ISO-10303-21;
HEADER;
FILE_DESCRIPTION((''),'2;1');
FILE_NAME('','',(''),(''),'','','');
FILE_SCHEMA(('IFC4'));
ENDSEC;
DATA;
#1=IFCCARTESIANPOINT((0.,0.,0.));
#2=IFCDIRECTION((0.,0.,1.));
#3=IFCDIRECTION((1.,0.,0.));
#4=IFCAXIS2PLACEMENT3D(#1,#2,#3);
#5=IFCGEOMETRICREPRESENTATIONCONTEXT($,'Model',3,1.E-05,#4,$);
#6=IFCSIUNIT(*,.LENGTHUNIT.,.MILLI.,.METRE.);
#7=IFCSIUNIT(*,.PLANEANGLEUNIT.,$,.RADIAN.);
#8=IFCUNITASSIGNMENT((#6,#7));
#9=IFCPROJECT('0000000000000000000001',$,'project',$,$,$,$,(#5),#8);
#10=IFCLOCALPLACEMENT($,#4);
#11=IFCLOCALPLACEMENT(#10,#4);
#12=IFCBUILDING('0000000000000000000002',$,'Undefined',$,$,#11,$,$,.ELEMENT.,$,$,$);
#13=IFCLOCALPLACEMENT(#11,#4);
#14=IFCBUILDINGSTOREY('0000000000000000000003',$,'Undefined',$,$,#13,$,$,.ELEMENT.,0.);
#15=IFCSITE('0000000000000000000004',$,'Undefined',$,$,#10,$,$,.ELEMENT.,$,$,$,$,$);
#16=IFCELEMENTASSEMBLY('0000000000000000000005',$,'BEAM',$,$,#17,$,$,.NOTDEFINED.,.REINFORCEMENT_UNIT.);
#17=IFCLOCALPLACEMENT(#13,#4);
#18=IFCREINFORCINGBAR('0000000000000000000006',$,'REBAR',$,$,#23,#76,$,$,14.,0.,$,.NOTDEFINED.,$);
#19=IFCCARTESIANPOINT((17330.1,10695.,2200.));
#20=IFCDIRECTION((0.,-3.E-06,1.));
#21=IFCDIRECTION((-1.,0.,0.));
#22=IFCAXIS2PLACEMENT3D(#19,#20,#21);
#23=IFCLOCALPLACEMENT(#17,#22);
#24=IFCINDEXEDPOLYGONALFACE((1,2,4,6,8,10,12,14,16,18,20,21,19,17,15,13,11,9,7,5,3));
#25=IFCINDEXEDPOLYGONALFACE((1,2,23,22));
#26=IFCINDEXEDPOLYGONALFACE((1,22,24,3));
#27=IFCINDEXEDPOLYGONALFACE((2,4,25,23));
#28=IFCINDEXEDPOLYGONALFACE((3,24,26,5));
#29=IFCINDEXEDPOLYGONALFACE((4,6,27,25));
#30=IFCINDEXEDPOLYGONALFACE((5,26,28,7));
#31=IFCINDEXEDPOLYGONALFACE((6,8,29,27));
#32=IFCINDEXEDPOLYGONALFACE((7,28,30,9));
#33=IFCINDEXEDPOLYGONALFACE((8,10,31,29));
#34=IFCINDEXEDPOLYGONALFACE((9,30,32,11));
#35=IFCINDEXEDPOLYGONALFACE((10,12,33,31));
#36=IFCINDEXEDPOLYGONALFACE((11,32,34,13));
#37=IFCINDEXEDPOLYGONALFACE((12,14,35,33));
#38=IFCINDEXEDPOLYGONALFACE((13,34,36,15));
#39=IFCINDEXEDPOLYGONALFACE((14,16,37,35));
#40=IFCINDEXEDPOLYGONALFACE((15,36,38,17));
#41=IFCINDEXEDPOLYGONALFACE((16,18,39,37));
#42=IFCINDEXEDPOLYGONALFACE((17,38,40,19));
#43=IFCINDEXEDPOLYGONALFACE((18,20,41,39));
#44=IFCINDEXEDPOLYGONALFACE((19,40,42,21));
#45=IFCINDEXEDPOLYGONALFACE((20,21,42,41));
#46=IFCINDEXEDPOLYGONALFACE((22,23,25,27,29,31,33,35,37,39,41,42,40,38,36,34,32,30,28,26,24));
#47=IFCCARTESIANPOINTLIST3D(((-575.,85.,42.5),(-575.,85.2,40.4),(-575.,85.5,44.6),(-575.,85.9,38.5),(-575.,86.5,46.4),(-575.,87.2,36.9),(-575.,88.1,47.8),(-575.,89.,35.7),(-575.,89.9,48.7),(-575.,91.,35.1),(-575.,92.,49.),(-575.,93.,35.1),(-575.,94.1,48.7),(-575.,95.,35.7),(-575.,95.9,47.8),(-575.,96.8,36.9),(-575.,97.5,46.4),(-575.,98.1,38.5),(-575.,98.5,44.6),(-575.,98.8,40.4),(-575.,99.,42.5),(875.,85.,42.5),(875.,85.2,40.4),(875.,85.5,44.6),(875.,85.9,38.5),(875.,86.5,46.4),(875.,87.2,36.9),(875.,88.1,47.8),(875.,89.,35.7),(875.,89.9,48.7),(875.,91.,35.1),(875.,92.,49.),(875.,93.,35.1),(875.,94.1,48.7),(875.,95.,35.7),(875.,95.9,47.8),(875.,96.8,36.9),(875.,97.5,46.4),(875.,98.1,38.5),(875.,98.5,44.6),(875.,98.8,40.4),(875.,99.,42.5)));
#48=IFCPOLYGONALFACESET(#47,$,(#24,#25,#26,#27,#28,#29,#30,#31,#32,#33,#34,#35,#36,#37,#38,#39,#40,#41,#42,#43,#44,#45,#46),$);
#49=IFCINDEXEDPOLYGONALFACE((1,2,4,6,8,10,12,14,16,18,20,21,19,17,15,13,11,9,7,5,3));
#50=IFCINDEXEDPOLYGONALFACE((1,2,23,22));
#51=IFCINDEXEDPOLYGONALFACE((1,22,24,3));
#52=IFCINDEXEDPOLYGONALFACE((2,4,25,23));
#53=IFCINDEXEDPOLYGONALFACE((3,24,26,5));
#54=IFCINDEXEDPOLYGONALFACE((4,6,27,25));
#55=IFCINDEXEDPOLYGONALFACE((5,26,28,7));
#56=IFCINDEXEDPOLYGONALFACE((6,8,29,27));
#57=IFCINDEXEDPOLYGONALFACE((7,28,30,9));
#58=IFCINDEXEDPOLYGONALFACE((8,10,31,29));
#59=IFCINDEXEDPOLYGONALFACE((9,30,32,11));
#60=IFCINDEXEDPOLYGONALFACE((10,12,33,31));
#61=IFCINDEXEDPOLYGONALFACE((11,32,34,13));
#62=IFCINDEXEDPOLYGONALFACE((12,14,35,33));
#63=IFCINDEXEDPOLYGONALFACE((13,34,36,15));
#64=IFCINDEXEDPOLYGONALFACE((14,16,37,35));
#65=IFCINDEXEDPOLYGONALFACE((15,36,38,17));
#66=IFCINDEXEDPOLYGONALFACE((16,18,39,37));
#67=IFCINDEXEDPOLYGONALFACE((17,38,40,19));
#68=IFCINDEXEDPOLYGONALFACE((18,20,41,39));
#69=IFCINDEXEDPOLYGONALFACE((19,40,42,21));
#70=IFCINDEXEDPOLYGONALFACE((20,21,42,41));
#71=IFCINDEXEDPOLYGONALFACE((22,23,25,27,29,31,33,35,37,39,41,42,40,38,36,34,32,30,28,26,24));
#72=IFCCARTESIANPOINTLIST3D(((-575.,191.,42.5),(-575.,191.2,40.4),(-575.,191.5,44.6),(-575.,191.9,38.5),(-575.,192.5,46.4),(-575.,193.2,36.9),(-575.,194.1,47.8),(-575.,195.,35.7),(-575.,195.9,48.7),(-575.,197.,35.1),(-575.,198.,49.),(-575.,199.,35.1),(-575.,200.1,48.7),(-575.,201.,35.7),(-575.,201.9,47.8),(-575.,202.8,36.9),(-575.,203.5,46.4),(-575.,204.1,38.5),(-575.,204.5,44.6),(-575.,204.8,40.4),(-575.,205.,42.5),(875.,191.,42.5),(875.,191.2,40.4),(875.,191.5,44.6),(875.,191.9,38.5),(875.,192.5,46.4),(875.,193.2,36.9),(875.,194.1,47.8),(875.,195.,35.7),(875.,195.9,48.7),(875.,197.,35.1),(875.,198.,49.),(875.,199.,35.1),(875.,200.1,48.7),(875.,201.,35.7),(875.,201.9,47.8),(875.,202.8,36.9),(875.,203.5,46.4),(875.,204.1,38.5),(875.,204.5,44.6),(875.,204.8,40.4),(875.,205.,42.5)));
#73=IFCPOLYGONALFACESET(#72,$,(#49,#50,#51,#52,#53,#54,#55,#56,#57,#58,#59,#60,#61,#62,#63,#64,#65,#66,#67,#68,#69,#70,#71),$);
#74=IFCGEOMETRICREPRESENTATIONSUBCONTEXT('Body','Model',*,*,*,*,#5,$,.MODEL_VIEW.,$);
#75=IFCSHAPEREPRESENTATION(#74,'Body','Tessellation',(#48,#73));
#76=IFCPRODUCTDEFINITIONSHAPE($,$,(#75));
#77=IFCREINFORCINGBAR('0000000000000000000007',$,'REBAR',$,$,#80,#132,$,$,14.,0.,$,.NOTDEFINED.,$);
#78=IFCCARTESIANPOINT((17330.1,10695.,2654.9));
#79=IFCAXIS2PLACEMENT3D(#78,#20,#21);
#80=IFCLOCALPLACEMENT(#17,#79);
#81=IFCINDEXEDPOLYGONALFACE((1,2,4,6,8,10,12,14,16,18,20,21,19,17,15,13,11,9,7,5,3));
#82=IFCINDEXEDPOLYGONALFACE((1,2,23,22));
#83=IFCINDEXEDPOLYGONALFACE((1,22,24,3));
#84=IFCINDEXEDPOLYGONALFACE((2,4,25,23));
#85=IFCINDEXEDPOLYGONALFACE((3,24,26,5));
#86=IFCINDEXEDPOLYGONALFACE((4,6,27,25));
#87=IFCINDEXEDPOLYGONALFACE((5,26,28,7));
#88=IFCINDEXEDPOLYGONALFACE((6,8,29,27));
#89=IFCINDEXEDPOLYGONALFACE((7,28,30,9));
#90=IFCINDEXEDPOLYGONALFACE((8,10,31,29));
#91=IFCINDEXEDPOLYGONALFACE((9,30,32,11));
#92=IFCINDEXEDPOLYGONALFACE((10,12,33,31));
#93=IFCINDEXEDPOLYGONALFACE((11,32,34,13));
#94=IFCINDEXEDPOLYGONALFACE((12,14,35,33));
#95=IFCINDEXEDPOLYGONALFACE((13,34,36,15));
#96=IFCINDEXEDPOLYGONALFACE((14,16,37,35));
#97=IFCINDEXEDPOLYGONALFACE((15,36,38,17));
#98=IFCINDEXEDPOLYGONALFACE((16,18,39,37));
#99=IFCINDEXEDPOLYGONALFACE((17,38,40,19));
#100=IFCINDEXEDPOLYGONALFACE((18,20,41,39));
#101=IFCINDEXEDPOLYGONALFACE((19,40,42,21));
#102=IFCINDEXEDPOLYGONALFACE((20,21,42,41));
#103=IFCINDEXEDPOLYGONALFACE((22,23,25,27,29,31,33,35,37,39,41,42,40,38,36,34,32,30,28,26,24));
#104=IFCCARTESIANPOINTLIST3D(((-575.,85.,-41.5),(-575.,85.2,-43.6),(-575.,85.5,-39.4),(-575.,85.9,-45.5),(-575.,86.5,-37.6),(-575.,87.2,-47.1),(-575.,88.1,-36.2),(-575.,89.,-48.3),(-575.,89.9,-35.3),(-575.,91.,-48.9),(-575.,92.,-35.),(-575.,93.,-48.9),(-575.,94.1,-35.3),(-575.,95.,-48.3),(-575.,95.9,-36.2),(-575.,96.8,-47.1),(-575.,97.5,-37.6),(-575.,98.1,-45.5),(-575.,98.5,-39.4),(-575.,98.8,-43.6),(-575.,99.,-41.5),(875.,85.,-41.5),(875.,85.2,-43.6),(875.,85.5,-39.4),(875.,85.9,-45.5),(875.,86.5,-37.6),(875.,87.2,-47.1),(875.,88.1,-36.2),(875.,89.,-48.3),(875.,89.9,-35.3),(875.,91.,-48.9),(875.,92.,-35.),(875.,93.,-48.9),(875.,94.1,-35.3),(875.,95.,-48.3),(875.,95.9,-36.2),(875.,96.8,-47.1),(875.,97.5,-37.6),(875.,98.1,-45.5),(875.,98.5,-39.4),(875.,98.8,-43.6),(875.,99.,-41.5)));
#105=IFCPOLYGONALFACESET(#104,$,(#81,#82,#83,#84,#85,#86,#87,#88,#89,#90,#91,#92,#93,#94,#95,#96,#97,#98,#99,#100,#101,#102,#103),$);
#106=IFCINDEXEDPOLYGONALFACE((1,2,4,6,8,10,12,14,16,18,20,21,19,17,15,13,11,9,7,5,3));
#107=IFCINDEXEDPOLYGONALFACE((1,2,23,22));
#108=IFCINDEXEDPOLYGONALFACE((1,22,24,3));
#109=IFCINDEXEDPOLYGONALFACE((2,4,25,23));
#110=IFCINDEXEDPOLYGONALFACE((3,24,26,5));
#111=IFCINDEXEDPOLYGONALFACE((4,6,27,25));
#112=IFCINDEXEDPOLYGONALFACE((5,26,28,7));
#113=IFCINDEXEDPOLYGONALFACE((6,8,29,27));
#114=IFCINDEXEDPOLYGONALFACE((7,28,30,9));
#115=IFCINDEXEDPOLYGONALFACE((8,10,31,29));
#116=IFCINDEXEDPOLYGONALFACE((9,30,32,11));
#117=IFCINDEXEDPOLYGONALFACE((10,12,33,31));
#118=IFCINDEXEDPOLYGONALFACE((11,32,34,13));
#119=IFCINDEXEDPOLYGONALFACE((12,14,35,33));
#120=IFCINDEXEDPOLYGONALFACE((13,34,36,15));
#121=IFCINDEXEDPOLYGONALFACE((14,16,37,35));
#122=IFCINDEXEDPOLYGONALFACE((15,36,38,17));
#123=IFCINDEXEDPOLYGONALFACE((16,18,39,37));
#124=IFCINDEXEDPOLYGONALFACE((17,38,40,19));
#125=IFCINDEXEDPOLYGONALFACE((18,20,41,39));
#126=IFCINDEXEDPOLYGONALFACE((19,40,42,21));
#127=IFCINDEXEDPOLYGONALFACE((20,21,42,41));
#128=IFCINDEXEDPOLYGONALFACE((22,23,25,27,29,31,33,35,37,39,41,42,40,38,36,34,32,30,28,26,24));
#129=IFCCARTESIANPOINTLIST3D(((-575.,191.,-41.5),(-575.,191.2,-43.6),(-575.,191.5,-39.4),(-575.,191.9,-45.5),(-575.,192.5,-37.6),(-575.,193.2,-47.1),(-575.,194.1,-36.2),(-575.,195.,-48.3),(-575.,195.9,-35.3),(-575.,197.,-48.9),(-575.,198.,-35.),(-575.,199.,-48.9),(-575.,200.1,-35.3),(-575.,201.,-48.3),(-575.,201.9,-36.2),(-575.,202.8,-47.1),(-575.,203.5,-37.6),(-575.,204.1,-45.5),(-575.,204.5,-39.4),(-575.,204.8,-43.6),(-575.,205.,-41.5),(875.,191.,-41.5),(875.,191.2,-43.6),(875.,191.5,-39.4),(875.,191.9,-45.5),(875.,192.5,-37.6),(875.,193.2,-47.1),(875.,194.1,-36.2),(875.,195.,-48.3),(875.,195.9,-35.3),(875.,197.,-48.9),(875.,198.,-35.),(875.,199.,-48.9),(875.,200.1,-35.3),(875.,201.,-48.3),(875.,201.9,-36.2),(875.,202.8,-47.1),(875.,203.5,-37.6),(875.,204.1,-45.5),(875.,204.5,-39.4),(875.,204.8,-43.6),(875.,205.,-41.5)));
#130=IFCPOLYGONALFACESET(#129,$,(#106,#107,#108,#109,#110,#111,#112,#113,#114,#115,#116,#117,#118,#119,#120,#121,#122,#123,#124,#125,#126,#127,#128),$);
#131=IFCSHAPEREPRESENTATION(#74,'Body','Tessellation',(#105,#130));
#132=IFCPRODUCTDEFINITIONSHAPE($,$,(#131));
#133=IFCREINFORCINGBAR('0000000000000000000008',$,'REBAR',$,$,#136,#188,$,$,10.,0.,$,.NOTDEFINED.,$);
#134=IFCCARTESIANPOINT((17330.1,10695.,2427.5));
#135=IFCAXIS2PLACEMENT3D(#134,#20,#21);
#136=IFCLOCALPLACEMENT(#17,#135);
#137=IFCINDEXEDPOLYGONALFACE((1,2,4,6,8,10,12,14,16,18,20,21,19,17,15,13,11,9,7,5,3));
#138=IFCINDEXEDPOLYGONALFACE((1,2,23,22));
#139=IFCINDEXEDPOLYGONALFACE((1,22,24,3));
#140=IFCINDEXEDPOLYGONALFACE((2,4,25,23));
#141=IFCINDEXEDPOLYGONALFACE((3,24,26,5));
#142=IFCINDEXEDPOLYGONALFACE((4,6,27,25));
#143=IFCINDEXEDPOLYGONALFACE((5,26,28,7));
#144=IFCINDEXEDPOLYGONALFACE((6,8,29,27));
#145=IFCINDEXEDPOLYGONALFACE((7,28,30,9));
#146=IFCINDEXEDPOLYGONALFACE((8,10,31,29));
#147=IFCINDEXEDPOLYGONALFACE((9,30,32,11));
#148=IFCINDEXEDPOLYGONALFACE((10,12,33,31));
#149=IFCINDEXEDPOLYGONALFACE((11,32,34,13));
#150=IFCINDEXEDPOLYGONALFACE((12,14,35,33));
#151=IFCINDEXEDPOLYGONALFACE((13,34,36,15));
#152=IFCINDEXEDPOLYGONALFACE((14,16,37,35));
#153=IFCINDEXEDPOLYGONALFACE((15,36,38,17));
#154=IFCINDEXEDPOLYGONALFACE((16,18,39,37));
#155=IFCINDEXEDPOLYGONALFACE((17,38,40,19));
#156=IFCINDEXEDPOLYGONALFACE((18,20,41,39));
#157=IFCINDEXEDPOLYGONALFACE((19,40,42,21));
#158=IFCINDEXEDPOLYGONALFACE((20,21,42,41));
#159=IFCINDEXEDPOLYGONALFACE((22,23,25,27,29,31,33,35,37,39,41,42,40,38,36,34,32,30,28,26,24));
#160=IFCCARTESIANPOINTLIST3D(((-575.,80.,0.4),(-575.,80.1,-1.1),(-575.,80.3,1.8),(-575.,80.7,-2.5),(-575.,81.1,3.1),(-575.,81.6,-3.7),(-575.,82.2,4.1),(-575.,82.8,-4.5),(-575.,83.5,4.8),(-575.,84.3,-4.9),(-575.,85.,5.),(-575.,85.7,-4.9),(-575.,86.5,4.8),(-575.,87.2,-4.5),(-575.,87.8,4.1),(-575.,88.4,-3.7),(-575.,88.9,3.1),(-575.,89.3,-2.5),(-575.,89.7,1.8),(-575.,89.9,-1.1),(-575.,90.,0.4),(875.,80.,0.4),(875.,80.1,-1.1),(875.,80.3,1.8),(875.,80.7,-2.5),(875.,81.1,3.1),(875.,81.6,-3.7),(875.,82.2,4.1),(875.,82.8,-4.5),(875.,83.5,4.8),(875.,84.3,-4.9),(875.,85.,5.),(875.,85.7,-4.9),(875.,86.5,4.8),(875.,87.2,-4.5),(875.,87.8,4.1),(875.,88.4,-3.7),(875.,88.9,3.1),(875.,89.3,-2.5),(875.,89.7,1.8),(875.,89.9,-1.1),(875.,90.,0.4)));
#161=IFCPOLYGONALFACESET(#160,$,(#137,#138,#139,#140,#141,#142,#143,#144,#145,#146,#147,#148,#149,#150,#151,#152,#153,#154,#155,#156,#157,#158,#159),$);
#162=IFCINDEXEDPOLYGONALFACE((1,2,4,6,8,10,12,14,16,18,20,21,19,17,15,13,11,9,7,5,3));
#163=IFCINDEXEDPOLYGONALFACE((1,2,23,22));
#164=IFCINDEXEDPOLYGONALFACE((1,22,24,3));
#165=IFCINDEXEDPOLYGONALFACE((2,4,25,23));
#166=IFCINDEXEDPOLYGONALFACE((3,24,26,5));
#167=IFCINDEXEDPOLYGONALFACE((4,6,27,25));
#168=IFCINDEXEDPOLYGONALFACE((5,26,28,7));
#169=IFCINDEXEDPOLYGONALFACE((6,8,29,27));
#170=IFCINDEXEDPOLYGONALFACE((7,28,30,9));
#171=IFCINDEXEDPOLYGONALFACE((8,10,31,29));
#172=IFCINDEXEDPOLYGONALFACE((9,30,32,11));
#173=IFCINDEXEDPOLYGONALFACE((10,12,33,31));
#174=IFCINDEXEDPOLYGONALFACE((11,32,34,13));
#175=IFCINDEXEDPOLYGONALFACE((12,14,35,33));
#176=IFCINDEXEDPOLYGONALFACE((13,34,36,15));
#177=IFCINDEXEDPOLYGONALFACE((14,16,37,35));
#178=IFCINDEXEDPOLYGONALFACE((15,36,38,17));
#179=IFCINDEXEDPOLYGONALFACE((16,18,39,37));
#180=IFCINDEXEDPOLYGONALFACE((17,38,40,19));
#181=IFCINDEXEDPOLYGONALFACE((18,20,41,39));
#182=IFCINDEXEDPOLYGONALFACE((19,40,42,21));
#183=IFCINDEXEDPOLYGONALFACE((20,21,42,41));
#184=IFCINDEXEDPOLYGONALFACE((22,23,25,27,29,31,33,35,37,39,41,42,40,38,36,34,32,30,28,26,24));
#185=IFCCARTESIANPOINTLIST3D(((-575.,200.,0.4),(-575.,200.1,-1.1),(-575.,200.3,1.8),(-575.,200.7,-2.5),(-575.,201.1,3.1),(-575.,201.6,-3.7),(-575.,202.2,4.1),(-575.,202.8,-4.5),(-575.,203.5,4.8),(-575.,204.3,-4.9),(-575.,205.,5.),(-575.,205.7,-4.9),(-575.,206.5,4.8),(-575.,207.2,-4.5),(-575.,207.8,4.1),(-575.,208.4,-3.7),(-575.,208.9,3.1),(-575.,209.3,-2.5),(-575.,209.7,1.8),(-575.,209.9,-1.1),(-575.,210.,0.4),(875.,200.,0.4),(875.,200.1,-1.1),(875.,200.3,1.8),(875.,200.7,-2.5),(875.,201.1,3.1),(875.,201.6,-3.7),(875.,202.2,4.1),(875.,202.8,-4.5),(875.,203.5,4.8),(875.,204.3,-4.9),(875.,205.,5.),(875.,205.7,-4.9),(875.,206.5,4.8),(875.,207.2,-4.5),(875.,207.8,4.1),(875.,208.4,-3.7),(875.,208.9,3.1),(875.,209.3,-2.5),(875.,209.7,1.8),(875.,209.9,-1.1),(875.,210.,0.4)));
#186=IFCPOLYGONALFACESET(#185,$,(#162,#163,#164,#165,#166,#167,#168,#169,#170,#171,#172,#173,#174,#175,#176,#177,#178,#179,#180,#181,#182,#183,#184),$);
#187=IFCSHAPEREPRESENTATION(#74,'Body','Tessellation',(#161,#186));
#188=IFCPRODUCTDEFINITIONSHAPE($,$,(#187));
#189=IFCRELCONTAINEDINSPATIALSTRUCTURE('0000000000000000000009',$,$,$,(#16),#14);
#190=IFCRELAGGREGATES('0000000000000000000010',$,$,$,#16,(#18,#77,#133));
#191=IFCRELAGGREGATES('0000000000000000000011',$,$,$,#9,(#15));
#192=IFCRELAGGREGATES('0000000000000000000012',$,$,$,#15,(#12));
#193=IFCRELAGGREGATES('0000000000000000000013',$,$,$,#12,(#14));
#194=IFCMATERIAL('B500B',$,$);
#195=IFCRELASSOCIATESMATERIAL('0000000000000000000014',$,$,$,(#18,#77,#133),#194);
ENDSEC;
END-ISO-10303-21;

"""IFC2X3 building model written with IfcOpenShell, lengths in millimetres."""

from ifc_helpers import new_model, entity, si_unit, frame, origin_with_axes, place, context, subcontext, project, spatial, source, transform, mapped, material, element, aggregate, save


model = new_model("IFC2X3")

# Units and contexts
model_context = context("Model", 3, precision=1e-05, world=origin_with_axes())
body_context = subcontext(model_context, "Body", "Model", "MODEL_VIEW")
ifc_project = project(units=[si_unit("LENGTHUNIT", "METRE", prefix="MILLI"), si_unit("PLANEANGLEUNIT", "RADIAN")], contexts=[model_context])

# Site, building, storey
site_placement = place(None, origin_with_axes())
site = spatial("IfcSite", under=ifc_project, at=site_placement, Name="Undefined", CompositionType="ELEMENT")
building_placement = place(site_placement, origin_with_axes())
building = spatial("IfcBuilding", under=site, at=building_placement, Name="Undefined", CompositionType="ELEMENT")
storey_placement = place(building_placement, origin_with_axes())
storey = spatial("IfcBuildingStorey", under=building, at=storey_placement, Name="Undefined", CompositionType="ELEMENT", Elevation=0.0)

# Element assembly
assembly_1_placement = place(storey_placement, origin_with_axes())
assembly_1 = element("IfcElementAssembly", 1, at=assembly_1_placement, inside=storey, Name="BEAM", AssemblyPlace="NOTDEFINED", PredefinedType="REINFORCEMENT_UNIT")

# Shared definitions
ifc_material_1 = material(Name="B500B")

# Reinforcing bars
shared_shape_1 = source(origin_with_axes(), body_context, "Body", "AdvancedSweptSolid", [
    entity("IfcSweptDiskSolid", entity("IfcTrimmedCurve", entity("IfcLine", entity("IfcCartesianPoint", [0.0, 0.0, 0.0]), entity("IfcVector", entity("IfcDirection", [1.0, 0.0, 0.0]), 1.0)), [entity("IfcParameterValue", 0.0)], [entity("IfcParameterValue", 1449.999613)], True, "PARAMETER"), 7.0, None, 0.0, 1450.0),
])
shared_shape_2 = source(origin_with_axes(), body_context, "Body", "AdvancedSweptSolid", [
    entity("IfcSweptDiskSolid", entity("IfcTrimmedCurve", entity("IfcLine", entity("IfcCartesianPoint", [0.0, 0.0, 0.0]), entity("IfcVector", entity("IfcDirection", [1.0, 0.0, 0.0]), 1.0)), [entity("IfcParameterValue", 0.0)], [entity("IfcParameterValue", 1449.999613)], True, "PARAMETER"), 7.0, None, 0.0, 1450.0),
])
reinforcing_bar_1_placement = place(assembly_1_placement, frame((17330.1, 10695.0, 2200.0), z_axis=(0.0, -0.000003, 1.0), x_axis=(-1.0, 0.0, 0.0)))
reinforcing_bar_1 = element("IfcReinforcingBar", 2, at=reinforcing_bar_1_placement, material=ifc_material_1, Name="REBAR", BarRole="NOTDEFINED", CrossSectionArea=0.0, NominalDiameter=14.0, context=body_context, shape_type="MappedRepresentation", body=[
    mapped(shared_shape_1, transform((-575.0, 92.0, 42.0))),
    mapped(shared_shape_2, transform((-575.0, 198.0, 42.0))),
])
shared_shape_3 = source(origin_with_axes(), body_context, "Body", "AdvancedSweptSolid", [
    entity("IfcSweptDiskSolid", entity("IfcTrimmedCurve", entity("IfcLine", entity("IfcCartesianPoint", [0.0, 0.0, 0.0]), entity("IfcVector", entity("IfcDirection", [1.0, 0.0, 0.0]), 1.0)), [entity("IfcParameterValue", 0.0)], [entity("IfcParameterValue", 1449.999613)], True, "PARAMETER"), 7.0, None, 0.0, 1450.0),
])
shared_shape_4 = source(origin_with_axes(), body_context, "Body", "AdvancedSweptSolid", [
    entity("IfcSweptDiskSolid", entity("IfcTrimmedCurve", entity("IfcLine", entity("IfcCartesianPoint", [0.0, 0.0, 0.0]), entity("IfcVector", entity("IfcDirection", [1.0, 0.0, 0.0]), 1.0)), [entity("IfcParameterValue", 0.0)], [entity("IfcParameterValue", 1449.999613)], True, "PARAMETER"), 7.0, None, 0.0, 1450.0),
])
reinforcing_bar_2_placement = place(assembly_1_placement, frame((17330.1, 10695.0, 2654.9), z_axis=(0.0, -0.000003, 1.0), x_axis=(-1.0, 0.0, 0.0)))
reinforcing_bar_2 = element("IfcReinforcingBar", 3, at=reinforcing_bar_2_placement, material=ifc_material_1, Name="REBAR", BarRole="NOTDEFINED", CrossSectionArea=0.0, NominalDiameter=14.0, context=body_context, shape_type="MappedRepresentation", body=[
    mapped(shared_shape_3, transform((-575.0, 92.0, -42.0))),
    mapped(shared_shape_4, transform((-575.0, 198.0, -42.0))),
])
shared_shape_5 = source(origin_with_axes(), body_context, "Body", "AdvancedSweptSolid", [
    entity("IfcSweptDiskSolid", entity("IfcTrimmedCurve", entity("IfcLine", entity("IfcCartesianPoint", [0.0, 0.0, 0.0]), entity("IfcVector", entity("IfcDirection", [1.0, 0.0, 0.0]), 1.0)), [entity("IfcParameterValue", 0.0)], [entity("IfcParameterValue", 1449.999613)], True, "PARAMETER"), 5.0, None, 0.0, 1450.0),
])
shared_shape_6 = source(origin_with_axes(), body_context, "Body", "AdvancedSweptSolid", [
    entity("IfcSweptDiskSolid", entity("IfcTrimmedCurve", entity("IfcLine", entity("IfcCartesianPoint", [0.0, 0.0, 0.0]), entity("IfcVector", entity("IfcDirection", [1.0, 0.0, 0.0]), 1.0)), [entity("IfcParameterValue", 0.0)], [entity("IfcParameterValue", 1449.999613)], True, "PARAMETER"), 5.0, None, 0.0, 1450.0),
])
reinforcing_bar_3_placement = place(assembly_1_placement, frame((17330.1, 10695.0, 2427.5), z_axis=(0.0, -0.000003, 1.0), x_axis=(-1.0, 0.0, 0.0)))
reinforcing_bar_3 = element("IfcReinforcingBar", 4, at=reinforcing_bar_3_placement, material=ifc_material_1, Name="REBAR", BarRole="NOTDEFINED", CrossSectionArea=0.0, NominalDiameter=10.0, context=body_context, shape_type="MappedRepresentation", body=[
    mapped(shared_shape_5, transform((-575.0, 85.0, 0.0))),
    mapped(shared_shape_6, transform((-575.0, 205.0, 0.0))),
])
aggregate(assembly_1, [reinforcing_bar_1, reinforcing_bar_2, reinforcing_bar_3])

save(model, "model.ifc")
